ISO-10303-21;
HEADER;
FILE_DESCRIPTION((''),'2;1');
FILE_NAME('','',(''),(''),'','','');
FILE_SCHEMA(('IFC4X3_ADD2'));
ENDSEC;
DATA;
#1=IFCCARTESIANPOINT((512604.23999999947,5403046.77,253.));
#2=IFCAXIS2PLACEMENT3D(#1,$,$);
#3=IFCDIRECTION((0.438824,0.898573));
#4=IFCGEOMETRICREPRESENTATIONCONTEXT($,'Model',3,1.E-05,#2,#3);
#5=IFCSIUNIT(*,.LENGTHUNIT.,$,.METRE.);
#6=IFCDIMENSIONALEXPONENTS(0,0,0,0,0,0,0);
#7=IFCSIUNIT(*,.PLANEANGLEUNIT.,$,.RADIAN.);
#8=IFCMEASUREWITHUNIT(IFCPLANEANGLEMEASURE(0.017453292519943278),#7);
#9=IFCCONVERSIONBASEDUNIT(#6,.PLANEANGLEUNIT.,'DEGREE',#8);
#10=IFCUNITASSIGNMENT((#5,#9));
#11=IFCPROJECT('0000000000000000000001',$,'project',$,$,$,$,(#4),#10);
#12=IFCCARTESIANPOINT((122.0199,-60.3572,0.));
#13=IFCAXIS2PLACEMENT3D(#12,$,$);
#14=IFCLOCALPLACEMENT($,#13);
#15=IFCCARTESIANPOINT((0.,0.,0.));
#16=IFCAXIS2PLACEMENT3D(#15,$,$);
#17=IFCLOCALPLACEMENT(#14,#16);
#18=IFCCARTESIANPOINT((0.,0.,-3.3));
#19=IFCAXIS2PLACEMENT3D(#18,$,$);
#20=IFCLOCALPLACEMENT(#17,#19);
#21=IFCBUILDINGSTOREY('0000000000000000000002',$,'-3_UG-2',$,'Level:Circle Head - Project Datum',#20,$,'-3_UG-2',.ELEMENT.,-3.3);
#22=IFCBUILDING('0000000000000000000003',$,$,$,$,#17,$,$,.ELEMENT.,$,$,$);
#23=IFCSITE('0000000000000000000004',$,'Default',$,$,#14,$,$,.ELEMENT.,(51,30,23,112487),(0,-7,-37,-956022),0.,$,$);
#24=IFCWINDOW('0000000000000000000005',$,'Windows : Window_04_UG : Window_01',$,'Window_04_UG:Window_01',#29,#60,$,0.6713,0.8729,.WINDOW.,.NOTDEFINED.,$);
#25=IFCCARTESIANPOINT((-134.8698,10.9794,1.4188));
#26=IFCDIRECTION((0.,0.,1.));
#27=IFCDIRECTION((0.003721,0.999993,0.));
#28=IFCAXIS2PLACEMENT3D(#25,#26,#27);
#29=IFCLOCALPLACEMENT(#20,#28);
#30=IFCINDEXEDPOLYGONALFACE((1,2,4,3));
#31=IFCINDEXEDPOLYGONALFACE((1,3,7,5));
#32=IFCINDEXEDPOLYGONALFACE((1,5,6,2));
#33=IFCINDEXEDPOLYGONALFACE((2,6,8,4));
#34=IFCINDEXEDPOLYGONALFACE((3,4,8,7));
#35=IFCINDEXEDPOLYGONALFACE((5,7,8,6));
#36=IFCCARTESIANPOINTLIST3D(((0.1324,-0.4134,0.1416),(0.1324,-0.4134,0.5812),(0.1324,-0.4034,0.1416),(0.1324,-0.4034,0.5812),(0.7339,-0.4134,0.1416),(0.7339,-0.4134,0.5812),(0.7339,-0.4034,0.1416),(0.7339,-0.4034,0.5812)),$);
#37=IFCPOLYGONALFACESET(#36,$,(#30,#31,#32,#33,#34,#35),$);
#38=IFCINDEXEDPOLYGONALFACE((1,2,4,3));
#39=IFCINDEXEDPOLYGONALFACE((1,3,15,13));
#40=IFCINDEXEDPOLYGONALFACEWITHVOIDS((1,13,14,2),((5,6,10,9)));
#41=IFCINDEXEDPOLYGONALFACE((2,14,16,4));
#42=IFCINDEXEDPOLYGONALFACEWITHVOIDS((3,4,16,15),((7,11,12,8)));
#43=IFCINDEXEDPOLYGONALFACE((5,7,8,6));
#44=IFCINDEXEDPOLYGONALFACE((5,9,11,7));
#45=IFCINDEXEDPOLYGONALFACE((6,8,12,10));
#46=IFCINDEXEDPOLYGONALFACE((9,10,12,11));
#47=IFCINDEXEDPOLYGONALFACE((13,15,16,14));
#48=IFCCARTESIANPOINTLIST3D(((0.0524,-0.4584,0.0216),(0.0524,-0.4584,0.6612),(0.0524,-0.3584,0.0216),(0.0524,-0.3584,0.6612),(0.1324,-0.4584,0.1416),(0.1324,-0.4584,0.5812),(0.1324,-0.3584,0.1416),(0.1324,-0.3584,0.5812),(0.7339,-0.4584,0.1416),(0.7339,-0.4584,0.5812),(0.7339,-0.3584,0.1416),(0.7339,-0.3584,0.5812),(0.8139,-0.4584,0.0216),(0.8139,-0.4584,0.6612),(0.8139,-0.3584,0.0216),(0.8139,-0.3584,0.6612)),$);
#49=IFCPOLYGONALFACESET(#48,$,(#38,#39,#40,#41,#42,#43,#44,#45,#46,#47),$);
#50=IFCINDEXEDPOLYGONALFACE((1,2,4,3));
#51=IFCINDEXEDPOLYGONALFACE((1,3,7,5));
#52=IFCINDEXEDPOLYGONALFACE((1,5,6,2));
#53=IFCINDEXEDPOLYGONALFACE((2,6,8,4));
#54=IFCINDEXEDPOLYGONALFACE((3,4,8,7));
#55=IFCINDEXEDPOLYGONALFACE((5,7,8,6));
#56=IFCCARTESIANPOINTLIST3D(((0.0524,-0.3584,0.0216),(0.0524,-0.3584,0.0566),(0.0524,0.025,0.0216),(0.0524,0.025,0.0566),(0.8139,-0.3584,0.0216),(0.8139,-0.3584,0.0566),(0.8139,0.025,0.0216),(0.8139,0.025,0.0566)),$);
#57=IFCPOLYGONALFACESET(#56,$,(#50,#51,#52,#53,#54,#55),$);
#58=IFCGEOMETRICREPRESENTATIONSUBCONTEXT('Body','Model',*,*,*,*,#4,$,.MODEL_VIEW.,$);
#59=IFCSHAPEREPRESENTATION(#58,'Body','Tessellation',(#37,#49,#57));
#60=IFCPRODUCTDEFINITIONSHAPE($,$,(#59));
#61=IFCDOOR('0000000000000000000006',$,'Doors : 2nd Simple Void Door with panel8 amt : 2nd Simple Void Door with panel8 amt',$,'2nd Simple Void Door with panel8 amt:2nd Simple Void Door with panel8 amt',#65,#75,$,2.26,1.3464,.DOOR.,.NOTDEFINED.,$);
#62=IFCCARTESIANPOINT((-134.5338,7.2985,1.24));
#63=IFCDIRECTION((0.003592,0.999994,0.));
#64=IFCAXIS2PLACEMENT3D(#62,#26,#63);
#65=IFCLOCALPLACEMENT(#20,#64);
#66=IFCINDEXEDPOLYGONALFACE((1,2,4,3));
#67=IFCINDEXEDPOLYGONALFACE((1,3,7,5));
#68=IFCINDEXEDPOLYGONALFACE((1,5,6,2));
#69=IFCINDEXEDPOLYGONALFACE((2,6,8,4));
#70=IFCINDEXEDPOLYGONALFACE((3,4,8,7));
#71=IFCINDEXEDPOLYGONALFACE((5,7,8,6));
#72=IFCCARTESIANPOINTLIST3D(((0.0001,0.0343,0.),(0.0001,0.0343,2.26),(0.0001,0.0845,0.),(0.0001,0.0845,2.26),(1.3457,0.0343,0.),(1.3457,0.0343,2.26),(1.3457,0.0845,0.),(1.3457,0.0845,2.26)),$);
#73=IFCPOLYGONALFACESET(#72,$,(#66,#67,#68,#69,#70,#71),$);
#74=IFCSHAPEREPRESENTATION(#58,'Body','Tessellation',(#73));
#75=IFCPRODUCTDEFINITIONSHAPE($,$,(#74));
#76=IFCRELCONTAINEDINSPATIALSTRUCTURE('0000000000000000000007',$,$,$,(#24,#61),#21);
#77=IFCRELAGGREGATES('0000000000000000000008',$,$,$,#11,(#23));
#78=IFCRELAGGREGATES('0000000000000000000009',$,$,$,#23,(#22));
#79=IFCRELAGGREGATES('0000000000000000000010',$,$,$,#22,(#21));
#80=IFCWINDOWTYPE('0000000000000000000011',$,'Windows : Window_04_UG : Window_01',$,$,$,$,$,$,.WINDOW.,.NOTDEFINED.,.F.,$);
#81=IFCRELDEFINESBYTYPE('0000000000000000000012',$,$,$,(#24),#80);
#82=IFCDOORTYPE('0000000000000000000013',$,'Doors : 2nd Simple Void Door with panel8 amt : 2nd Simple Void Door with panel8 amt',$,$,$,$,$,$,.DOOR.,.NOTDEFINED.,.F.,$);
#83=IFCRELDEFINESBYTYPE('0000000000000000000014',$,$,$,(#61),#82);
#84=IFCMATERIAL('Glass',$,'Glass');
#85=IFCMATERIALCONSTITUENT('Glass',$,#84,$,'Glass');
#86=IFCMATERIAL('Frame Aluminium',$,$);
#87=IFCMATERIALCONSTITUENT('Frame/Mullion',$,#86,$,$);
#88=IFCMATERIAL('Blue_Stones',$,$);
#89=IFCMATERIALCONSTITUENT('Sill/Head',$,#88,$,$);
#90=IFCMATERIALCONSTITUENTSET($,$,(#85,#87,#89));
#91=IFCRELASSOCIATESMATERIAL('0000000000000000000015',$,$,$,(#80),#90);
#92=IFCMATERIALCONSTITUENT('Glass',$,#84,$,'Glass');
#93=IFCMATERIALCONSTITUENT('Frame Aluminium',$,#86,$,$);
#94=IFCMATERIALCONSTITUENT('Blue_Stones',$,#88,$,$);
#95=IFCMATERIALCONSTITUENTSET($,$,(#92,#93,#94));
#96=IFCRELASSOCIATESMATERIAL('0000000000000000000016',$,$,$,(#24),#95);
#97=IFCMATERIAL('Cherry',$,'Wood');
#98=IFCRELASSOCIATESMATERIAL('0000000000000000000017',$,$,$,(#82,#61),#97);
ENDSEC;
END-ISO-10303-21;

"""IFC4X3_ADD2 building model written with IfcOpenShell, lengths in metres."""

from ifc_helpers import new_model, entity, si_unit, converted_unit, direction, frame, frame_2d, origin, origin_2d_with_axis, place, context, subcontext, project, spatial, polyline, rectangle, outline, extrude, source, transform, mapped, material, constituent, constituent_set, type_object, type_shapes, element, save


model = new_model("IFC4X3_ADD2")

# Units and contexts
model_context = context("Model", 3, precision=1e-05, world=frame((512604.23999999947, 5403046.77, 253.0)), true_north=direction((0.438824, 0.898573)))
body_context = subcontext(model_context, "Body", "Model", "MODEL_VIEW")
ifc_project = project(units=[si_unit("LENGTHUNIT", "METRE"), converted_unit("PLANEANGLEUNIT", "DEGREE", entity("IfcPlaneAngleMeasure", 0.017453292519943278), si_unit("PLANEANGLEUNIT", "RADIAN"), dimensions=[0, 0, 0, 0, 0, 0, 0])], contexts=[model_context])

# Site, building, storey
site_placement = place(None, frame((122.0199, -60.3572, 0.0)))
site = spatial("IfcSite", under=ifc_project, at=site_placement, Name="Default", CompositionType="ELEMENT", RefLatitude=(51, 30, 23, 112487), RefLongitude=(0, -7, -37, -956022), RefElevation=0.0)
building_placement = place(site_placement, origin())
building = spatial("IfcBuilding", under=site, at=building_placement, CompositionType="ELEMENT")
storey_placement = place(building_placement, frame((0.0, 0.0, -3.3)))
storey = spatial("IfcBuildingStorey", under=building, at=storey_placement, Name="-3_UG-2", ObjectType="Level:Circle Head - Project Datum", LongName="-3_UG-2", CompositionType="ELEMENT", Elevation=-3.3)

# Window
ifc_material_1 = material(Name="Glass", Category="Glass")
ifc_material_2 = material(Name="Blue_Stones")
ifc_material_3 = material(Name="Frame Aluminium")
ifc_constituent_1 = constituent(ifc_material_1, Name="Glass", Category="Glass")
ifc_constituent_2 = constituent(ifc_material_3, Name="Frame Aluminium")
ifc_constituent_3 = constituent(ifc_material_2, Name="Blue_Stones")
ifc_constituent_set_1 = constituent_set(constituents=[ifc_constituent_1, ifc_constituent_2, ifc_constituent_3])
ifc_constituent_4 = constituent(ifc_material_1, Name="Glass", Category="Glass")
ifc_constituent_5 = constituent(ifc_material_3, Name="Frame/Mullion")
ifc_constituent_6 = constituent(ifc_material_2, Name="Sill/Head")
ifc_constituent_set_2 = constituent_set(constituents=[ifc_constituent_4, ifc_constituent_5, ifc_constituent_6])
window_type_1 = type_object("IfcWindowType", Name="Windows : Window_04_UG : Window_01", ParameterTakesPrecedence=False, PartitioningType="NOTDEFINED", PredefinedType="WINDOW", material=ifc_constituent_set_2)
shared_shape_1 = source(origin(), body_context, "Body", "SweptSolid", [
    extrude(rectangle(XDim=0.6016, YDim=0.01, at=origin_2d_with_axis()), frame((0.4332, -0.4084, 0.1416), z_axis=(0.0, 0.0, 1.0), x_axis=(-1.0, 0.0, 0.0)), (0.0, 0.0, 1.0), 0.4397),
    extrude(outline(polyline([(-0.3198, -0.3808), (0.3198, -0.3808), (0.3198, 0.3808), (-0.3198, 0.3808), (-0.3198, -0.3808)]), holes=[polyline([(-0.1998, 0.3008), (0.2398, 0.3008), (0.2398, -0.3008), (-0.1998, -0.3008), (-0.1998, 0.3008)])]), frame((0.4332, -0.4584, 0.3414), z_axis=(0.0, 1.0, 0.0), x_axis=(0.0, 0.0, 1.0)), (0.0, 0.0, 1.0), 0.1),
    extrude(rectangle(XDim=0.3834, YDim=0.7616, at=frame_2d((0.0, 0.0), x_axis=(1.0, 0.0))), frame((0.4332, -0.1667, 0.0216), z_axis=(0.0, 0.0, 1.0), x_axis=(0.0, 1.0, 0.0)), (0.0, 0.0, 1.0), 0.035),
])
type_shapes(window_type_1, [shared_shape_1])
window_1_placement = place(storey_placement, frame((-134.8698, 10.9794, 1.4188), z_axis=(0.0, 0.0, 1.0), x_axis=(0.003721, 0.999993, 0.0)))
element("IfcWindow", 1, at=window_1_placement, inside=storey, type_object=window_type_1, material=ifc_constituent_set_1, Name="Windows : Window_04_UG : Window_01", ObjectType="Window_04_UG:Window_01", OverallHeight=0.6713, OverallWidth=0.8729, PartitioningType="NOTDEFINED", PredefinedType="WINDOW", context=body_context, shape_type="MappedRepresentation", body=[
    mapped(shared_shape_1, transform((0.0, 0.0, 0.0), scale=1.0)),
])

# Door
ifc_material_4 = material(Name="Cherry", Category="Wood")
door_type = type_object("IfcDoorType", Name="Doors : 2nd Simple Void Door with panel8 amt : 2nd Simple Void Door with panel8 amt", OperationType="NOTDEFINED", ParameterTakesPrecedence=False, PredefinedType="DOOR", material=ifc_material_4)
shared_shape_2 = source(origin(), body_context, "Body", "SweptSolid", [
    extrude(rectangle(XDim=0.0501, YDim=1.3456, at=frame_2d((0.0, 0.0), x_axis=(1.0, 0.0))), frame((0.6729, 0.0594, 0.0), z_axis=(0.0, 0.0, 1.0), x_axis=(0.0, 1.0, 0.0)), (0.0, 0.0, 1.0), 2.26),
])
type_shapes(door_type, [shared_shape_2])
door_placement = place(storey_placement, frame((-134.5338, 7.2985, 1.24), z_axis=(0.0, 0.0, 1.0), x_axis=(0.003592, 0.999994, 0.0)))
element("IfcDoor", 2, at=door_placement, inside=storey, type_object=door_type, material=ifc_material_4, Name="Doors : 2nd Simple Void Door with panel8 amt : 2nd Simple Void Door with panel8 amt", ObjectType="2nd Simple Void Door with panel8 amt:2nd Simple Void Door with panel8 amt", OperationType="NOTDEFINED", OverallHeight=2.26, OverallWidth=1.3464, PredefinedType="DOOR", context=body_context, shape_type="MappedRepresentation", body=[
    mapped(shared_shape_2, transform((0.0, 0.0, 0.0), scale=1.0)),
])

save(model, "model.ifc")
